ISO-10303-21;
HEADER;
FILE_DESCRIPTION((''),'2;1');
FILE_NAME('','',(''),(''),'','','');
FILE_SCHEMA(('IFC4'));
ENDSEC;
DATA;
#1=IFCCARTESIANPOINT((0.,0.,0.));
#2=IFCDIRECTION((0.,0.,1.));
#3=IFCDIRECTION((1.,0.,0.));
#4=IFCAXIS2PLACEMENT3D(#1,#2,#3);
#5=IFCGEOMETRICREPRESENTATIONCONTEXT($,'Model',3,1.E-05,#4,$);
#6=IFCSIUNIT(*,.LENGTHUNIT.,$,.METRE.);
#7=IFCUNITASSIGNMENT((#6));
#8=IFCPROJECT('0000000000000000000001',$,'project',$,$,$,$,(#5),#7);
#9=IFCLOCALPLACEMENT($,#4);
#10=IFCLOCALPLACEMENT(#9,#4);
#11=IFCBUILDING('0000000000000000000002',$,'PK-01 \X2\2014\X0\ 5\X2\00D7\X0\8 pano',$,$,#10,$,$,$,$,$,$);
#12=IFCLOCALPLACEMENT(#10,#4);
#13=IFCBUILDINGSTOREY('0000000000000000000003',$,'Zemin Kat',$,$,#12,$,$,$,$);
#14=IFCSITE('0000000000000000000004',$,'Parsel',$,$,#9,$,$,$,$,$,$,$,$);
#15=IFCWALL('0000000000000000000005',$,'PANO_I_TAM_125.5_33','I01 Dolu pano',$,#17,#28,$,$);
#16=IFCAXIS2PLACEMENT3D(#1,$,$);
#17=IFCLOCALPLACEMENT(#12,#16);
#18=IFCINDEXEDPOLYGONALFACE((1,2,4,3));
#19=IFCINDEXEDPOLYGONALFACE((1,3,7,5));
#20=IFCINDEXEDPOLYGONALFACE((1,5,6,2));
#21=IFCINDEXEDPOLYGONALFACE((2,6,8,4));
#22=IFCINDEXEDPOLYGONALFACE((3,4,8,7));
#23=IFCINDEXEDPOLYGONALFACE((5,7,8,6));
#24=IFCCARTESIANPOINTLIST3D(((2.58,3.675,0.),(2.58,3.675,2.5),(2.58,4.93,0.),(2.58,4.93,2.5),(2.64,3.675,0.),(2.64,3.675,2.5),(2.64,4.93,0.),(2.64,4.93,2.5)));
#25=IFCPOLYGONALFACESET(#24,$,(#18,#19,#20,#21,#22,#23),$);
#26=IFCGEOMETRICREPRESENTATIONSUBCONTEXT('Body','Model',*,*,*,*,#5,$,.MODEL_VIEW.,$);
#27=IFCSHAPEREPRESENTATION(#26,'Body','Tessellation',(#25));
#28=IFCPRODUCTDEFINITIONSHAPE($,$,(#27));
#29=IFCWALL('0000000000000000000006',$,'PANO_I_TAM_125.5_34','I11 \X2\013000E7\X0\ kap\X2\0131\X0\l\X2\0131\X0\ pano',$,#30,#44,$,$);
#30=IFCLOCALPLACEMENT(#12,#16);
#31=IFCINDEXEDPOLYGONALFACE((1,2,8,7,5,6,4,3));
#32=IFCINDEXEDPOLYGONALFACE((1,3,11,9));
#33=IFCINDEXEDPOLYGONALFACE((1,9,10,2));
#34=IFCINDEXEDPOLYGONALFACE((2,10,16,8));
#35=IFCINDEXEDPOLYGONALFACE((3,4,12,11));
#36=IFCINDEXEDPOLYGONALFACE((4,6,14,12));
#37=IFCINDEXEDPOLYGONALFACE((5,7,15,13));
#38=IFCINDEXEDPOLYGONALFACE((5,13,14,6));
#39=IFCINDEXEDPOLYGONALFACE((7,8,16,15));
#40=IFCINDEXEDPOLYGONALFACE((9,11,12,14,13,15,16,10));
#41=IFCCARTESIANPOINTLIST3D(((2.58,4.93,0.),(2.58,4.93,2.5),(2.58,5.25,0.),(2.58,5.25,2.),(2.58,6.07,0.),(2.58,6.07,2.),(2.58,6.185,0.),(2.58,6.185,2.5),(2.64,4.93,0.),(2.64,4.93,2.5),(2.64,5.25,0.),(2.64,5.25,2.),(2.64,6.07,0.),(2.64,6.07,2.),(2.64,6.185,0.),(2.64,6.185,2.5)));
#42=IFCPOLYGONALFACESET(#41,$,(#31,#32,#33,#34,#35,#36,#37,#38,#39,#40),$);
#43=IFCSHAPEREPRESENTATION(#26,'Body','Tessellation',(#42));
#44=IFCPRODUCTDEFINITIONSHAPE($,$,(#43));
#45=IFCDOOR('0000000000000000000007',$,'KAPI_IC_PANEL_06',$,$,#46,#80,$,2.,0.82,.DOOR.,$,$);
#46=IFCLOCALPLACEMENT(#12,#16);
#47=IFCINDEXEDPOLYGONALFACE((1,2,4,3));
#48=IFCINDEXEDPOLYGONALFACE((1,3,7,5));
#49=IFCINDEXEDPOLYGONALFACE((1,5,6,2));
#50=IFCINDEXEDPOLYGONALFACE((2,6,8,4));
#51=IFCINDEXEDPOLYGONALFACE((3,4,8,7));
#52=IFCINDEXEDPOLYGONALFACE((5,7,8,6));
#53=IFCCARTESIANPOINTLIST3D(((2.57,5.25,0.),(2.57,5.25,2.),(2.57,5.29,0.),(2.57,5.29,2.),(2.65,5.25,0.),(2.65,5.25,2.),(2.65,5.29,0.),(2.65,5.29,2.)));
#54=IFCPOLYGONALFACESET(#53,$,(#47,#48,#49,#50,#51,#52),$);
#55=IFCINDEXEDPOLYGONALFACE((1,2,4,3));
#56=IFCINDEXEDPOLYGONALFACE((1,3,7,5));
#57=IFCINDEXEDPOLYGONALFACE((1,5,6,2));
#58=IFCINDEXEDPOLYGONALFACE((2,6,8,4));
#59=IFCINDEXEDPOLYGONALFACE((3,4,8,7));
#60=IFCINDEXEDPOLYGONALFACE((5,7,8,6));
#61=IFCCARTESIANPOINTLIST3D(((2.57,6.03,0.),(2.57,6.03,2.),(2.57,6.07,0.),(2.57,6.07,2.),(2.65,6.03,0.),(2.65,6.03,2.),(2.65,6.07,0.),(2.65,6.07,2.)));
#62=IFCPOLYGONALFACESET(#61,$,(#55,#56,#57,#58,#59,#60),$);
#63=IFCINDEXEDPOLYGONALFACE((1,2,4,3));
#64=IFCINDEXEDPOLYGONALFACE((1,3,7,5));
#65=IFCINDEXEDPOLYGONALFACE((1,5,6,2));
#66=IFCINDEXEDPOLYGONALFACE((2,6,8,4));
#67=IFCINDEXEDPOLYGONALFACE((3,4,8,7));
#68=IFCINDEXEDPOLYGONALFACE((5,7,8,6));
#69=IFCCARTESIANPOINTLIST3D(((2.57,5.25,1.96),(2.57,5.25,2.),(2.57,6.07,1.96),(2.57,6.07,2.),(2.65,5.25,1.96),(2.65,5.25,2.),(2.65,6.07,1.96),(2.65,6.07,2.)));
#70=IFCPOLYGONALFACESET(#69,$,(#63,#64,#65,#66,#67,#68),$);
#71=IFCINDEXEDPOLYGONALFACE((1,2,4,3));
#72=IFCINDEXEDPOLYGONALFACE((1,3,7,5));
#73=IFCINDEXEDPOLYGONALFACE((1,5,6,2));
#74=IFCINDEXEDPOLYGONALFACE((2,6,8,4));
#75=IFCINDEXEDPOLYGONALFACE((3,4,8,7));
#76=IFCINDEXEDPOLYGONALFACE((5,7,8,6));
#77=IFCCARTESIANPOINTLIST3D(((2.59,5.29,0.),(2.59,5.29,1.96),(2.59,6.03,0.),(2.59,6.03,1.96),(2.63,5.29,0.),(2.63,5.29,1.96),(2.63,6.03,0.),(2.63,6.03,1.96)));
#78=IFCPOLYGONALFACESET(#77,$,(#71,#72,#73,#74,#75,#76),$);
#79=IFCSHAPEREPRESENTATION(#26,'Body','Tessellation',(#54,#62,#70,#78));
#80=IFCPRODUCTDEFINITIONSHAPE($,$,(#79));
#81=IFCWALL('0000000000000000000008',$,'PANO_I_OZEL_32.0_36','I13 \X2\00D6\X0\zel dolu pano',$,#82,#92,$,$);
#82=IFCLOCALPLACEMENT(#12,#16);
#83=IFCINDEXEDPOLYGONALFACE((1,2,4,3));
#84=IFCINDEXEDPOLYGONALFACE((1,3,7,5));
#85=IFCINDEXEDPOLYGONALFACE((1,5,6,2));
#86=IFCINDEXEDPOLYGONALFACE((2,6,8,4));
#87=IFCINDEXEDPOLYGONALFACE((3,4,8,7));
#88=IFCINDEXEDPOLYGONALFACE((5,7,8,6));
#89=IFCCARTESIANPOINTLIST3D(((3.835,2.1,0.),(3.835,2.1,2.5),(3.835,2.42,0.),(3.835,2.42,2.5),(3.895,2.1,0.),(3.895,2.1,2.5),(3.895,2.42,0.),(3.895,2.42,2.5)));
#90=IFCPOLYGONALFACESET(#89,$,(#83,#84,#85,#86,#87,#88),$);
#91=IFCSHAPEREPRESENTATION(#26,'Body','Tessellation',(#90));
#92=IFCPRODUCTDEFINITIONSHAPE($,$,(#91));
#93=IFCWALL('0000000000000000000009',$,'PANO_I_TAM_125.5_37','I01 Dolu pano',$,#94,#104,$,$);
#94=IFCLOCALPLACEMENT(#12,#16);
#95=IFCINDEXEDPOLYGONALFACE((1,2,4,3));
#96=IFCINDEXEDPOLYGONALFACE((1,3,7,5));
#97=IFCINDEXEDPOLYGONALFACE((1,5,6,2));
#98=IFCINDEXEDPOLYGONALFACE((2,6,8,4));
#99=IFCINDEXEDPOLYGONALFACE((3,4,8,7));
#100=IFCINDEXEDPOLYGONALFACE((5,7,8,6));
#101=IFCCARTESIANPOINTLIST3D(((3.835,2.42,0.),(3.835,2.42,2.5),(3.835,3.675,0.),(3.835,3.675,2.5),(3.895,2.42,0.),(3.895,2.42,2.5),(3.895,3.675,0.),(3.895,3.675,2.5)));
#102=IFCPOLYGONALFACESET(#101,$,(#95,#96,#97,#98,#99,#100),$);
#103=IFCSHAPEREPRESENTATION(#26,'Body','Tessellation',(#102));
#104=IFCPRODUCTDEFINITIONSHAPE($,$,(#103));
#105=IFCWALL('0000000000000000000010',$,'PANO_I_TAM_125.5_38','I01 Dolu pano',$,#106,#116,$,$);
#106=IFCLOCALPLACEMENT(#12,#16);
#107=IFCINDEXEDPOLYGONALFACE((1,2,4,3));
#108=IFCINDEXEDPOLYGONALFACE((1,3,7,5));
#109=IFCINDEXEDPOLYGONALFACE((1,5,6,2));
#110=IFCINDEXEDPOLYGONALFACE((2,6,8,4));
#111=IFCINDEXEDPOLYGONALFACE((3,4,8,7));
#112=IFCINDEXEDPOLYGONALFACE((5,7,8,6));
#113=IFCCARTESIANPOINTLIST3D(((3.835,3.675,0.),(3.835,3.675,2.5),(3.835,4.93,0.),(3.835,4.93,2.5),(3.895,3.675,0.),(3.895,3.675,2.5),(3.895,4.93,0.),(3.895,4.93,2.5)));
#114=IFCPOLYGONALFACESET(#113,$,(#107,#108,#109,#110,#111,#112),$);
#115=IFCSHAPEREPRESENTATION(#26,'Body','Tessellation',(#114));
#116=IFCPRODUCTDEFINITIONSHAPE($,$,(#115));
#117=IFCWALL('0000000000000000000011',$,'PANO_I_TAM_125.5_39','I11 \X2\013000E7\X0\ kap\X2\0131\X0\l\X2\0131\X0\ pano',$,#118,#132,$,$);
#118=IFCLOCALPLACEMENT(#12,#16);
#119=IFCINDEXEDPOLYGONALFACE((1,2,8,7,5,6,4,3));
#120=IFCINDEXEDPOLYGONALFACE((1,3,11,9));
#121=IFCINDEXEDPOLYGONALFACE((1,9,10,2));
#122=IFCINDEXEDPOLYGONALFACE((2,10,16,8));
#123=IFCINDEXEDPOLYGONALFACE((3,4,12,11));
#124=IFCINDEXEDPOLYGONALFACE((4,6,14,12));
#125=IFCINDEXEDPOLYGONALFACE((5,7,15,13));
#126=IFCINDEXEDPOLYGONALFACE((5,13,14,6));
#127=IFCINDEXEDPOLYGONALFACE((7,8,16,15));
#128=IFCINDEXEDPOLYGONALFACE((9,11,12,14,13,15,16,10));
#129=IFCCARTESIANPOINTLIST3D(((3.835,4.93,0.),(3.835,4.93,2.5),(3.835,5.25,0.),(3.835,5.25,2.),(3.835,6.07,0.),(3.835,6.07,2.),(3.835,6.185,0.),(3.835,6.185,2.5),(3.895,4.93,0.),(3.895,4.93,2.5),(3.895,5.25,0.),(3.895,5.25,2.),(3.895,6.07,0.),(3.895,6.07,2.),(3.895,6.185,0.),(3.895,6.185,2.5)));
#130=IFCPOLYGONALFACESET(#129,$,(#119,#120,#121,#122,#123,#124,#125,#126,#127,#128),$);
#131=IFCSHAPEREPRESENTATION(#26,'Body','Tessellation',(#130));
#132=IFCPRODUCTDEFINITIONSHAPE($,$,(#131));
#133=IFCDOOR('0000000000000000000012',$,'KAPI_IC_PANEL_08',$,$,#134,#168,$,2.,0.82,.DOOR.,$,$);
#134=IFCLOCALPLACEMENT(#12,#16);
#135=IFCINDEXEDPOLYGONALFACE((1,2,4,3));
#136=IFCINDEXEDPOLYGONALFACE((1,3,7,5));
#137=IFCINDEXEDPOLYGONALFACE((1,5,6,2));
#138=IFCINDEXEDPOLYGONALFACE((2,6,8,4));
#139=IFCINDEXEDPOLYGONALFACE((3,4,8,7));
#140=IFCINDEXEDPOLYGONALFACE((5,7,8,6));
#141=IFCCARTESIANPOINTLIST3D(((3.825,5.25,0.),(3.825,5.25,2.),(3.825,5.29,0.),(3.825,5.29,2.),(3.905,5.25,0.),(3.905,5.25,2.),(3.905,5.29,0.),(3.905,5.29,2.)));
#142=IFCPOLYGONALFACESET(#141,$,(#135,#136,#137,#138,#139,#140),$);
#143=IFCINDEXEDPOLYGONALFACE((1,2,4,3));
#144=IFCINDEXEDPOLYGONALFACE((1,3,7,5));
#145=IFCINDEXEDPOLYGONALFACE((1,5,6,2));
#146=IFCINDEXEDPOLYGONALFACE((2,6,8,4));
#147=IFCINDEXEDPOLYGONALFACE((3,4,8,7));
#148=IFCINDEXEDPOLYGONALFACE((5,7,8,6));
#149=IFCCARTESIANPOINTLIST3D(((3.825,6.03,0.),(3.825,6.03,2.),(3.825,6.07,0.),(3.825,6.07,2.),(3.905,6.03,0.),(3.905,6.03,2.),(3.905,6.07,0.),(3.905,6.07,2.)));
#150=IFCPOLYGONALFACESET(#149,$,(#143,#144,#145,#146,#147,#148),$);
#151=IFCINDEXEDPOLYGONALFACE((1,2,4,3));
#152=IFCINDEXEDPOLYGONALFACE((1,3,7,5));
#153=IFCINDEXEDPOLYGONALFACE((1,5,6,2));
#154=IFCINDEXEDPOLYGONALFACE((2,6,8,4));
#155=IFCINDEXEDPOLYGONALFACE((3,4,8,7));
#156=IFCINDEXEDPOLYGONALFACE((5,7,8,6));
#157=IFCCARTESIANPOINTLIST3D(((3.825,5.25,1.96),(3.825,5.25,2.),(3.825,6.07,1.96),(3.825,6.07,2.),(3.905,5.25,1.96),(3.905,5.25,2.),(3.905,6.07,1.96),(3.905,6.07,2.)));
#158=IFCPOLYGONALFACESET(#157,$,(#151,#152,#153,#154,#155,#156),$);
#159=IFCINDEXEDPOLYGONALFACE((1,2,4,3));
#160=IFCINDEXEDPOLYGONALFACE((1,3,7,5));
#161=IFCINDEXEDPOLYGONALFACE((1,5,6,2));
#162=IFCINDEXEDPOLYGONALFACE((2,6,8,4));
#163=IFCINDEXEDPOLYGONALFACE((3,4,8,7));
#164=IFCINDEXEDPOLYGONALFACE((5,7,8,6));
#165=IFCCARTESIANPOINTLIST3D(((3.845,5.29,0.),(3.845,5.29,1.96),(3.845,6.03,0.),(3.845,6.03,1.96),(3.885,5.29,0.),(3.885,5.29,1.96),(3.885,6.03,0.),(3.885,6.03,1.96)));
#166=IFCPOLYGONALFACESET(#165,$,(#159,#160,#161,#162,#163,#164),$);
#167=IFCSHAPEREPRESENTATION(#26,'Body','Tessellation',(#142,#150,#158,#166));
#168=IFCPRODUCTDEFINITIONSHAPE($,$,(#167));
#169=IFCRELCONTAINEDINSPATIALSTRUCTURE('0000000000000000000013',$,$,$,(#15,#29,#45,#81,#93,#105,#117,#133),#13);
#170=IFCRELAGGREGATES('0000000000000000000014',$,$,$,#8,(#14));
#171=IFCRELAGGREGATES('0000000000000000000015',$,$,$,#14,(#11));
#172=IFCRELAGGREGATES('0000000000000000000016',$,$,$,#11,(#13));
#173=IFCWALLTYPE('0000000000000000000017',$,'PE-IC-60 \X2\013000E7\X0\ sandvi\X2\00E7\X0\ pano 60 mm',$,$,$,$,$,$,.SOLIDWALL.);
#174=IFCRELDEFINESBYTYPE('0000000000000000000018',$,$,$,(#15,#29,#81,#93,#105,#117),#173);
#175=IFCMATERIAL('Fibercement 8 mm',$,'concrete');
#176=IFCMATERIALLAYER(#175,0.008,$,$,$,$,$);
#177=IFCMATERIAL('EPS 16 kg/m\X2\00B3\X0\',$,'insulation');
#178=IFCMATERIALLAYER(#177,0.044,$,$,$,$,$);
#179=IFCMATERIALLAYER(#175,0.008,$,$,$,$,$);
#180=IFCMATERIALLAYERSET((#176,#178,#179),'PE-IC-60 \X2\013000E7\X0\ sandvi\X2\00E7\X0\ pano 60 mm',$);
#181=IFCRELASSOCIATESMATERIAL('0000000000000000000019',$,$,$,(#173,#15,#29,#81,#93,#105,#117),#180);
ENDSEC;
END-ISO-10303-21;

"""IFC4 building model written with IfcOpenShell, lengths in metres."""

from ifc_helpers import new_model, si_unit, frame, origin_with_axes, place, context, subcontext, project, spatial, line, indexed_curve, outline, extrude, material, layer, layer_set, layer_usage, type_object, element, fill, save


model = new_model("IFC4")

# Units and contexts
model_context = context("Model", 3, precision=1e-05, world=origin_with_axes())
body_context = subcontext(model_context, "Body", "Model", "MODEL_VIEW")
ifc_project = project(units=[si_unit("LENGTHUNIT", "METRE")], contexts=[model_context])

# Site, building, storey
site_placement = place(None, origin_with_axes())
site = spatial("IfcSite", under=ifc_project, at=site_placement, Name="Parsel")
building_placement = place(site_placement, origin_with_axes())
building = spatial("IfcBuilding", under=site, at=building_placement, Name="PK-01 — 5×8 pano")
storey_placement = place(building_placement, origin_with_axes())
storey = spatial("IfcBuildingStorey", under=building, at=storey_placement, Name="Zemin Kat")

# Shared definitions
ifc_material_1 = material(Name="Fibercement 8 mm", Category="concrete")
ifc_material_2 = material(Name="EPS 16 kg/m³", Category="insulation")

# Wall
ifc_layer_1 = layer(ifc_material_1, 0.008)
ifc_layer_2 = layer(ifc_material_2, 0.044)
ifc_layer_3 = layer(ifc_material_1, 0.008)
ifc_layer_set_1 = layer_set([ifc_layer_1, ifc_layer_2, ifc_layer_3], Name="PE-IC-60 İç sandviç pano 60 mm")
wall_type_1 = type_object("IfcWallType", Name="PE-IC-60 İç sandviç pano 60 mm", PredefinedType="SOLIDWALL", material=ifc_layer_set_1)
ifc_layer_usage_1 = layer_usage(ifc_layer_set_1, "AXIS2", "POSITIVE", 0.0)
wall_1_placement = place(storey_placement, frame((2.64, 3.675, 0.0), z_axis=(0.0, 0.0, 1.0), x_axis=(0.0, 1.0, 0.0)))
element("IfcWall", 1, at=wall_1_placement, inside=storey, type_object=wall_type_1, material=ifc_layer_usage_1, Name="PANO_I_TAM_125.5_33", Description="I01 Dolu pano", context=body_context, shape_type="SweptSolid", body=[
    extrude(outline(indexed_curve([(0.0, 0.0), (1.255, 0.0), (1.255, 0.06), (0.0, 0.06)], segments=[line(1, 2, 3, 4, 1)])), origin_with_axes(), (0.0, 0.0, 1.0), 2.5),
])

# Wall, opening, door
ifc_layer_usage_2 = layer_usage(ifc_layer_set_1, "AXIS2", "POSITIVE", 0.0)
wall_2_placement = place(storey_placement, frame((2.64, 4.93, 0.0), z_axis=(0.0, 0.0, 1.0), x_axis=(0.0, 1.0, 0.0)))
wall_2 = element("IfcWall", 2, at=wall_2_placement, inside=storey, type_object=wall_type_1, material=ifc_layer_usage_2, Name="PANO_I_TAM_125.5_34", Description="I11 İç kapılı pano", context=body_context, shape_type="SweptSolid", body=[
    extrude(outline(indexed_curve([(0.0, 0.0), (1.255, 0.0), (1.255, 0.06), (0.0, 0.06)], segments=[line(1, 2, 3, 4, 1)])), origin_with_axes(), (0.0, 0.0, 1.0), 2.5),
])
opening_1_placement = place(wall_2_placement, origin_with_axes())
opening_1 = element("IfcOpeningElement", 3, at=opening_1_placement, cuts=wall_2, PredefinedType="OPENING", context=body_context, shape_type="SweptSolid", body=[
    extrude(outline(indexed_curve([(0.0, 0.0), (0.82, 0.0), (0.82, 0.1), (0.0, 0.1)], segments=[line(1, 2, 3, 4, 1)])), frame((0.32, -0.02, 0.0), z_axis=(0.0, 0.0, 1.0), x_axis=(1.0, 0.0, 0.0)), (0.0, 0.0, 1.0), 2.0),
])
door_1_placement = place(storey_placement, frame((2.64, 4.93, 0.0), z_axis=(0.0, 0.0, 1.0), x_axis=(0.0, 1.0, 0.0)))
door_1 = element("IfcDoor", 4, at=door_1_placement, inside=storey, Name="KAPI_IC_PANEL_06", OverallHeight=2.0, OverallWidth=0.82, PredefinedType="DOOR", context=body_context, shape_type="SweptSolid", body=[
    extrude(outline(indexed_curve([(0.0, 0.0), (0.04, 0.0), (0.04, 0.08), (0.0, 0.08)], segments=[line(1, 2, 3, 4, 1)])), frame((0.32, -0.01, 0.0), z_axis=(0.0, 0.0, 1.0), x_axis=(1.0, 0.0, 0.0)), (0.0, 0.0, 1.0), 2.0),
    extrude(outline(indexed_curve([(0.0, 0.0), (0.04, 0.0), (0.04, 0.08), (0.0, 0.08)], segments=[line(1, 2, 3, 4, 1)])), frame((1.1, -0.01, 0.0), z_axis=(0.0, 0.0, 1.0), x_axis=(1.0, 0.0, 0.0)), (0.0, 0.0, 1.0), 2.0),
    extrude(outline(indexed_curve([(0.0, 0.0), (0.82, 0.0), (0.82, 0.08), (0.0, 0.08)], segments=[line(1, 2, 3, 4, 1)])), frame((0.32, -0.01, 1.96), z_axis=(0.0, 0.0, 1.0), x_axis=(1.0, 0.0, 0.0)), (0.0, 0.0, 1.0), 0.04),
    extrude(outline(indexed_curve([(0.0, 0.0), (0.74, 0.0), (0.74, 0.04), (0.0, 0.04)], segments=[line(1, 2, 3, 4, 1)])), frame((0.36, 0.01, 0.0), z_axis=(0.0, 0.0, 1.0), x_axis=(1.0, 0.0, 0.0)), (0.0, 0.0, 1.0), 1.96),
])
fill(opening_1, door_1)

# Walls
ifc_layer_usage_3 = layer_usage(ifc_layer_set_1, "AXIS2", "POSITIVE", 0.0)
wall_3_placement = place(storey_placement, frame((3.895, 2.1, 0.0), z_axis=(0.0, 0.0, 1.0), x_axis=(0.0, 1.0, 0.0)))
element("IfcWall", 5, at=wall_3_placement, inside=storey, type_object=wall_type_1, material=ifc_layer_usage_3, Name="PANO_I_OZEL_32.0_36", Description="I13 Özel dolu pano", context=body_context, shape_type="SweptSolid", body=[
    extrude(outline(indexed_curve([(0.0, 0.0), (0.32, 0.0), (0.32, 0.06), (0.0, 0.06)], segments=[line(1, 2, 3, 4, 1)])), origin_with_axes(), (0.0, 0.0, 1.0), 2.5),
])
ifc_layer_usage_4 = layer_usage(ifc_layer_set_1, "AXIS2", "POSITIVE", 0.0)
wall_4_placement = place(storey_placement, frame((3.895, 2.42, 0.0), z_axis=(0.0, 0.0, 1.0), x_axis=(0.0, 1.0, 0.0)))
element("IfcWall", 6, at=wall_4_placement, inside=storey, type_object=wall_type_1, material=ifc_layer_usage_4, Name="PANO_I_TAM_125.5_37", Description="I01 Dolu pano", context=body_context, shape_type="SweptSolid", body=[
    extrude(outline(indexed_curve([(0.0, 0.0), (1.255, 0.0), (1.255, 0.06), (0.0, 0.06)], segments=[line(1, 2, 3, 4, 1)])), origin_with_axes(), (0.0, 0.0, 1.0), 2.5),
])
ifc_layer_usage_5 = layer_usage(ifc_layer_set_1, "AXIS2", "POSITIVE", 0.0)
wall_5_placement = place(storey_placement, frame((3.895, 3.675, 0.0), z_axis=(0.0, 0.0, 1.0), x_axis=(0.0, 1.0, 0.0)))
element("IfcWall", 7, at=wall_5_placement, inside=storey, type_object=wall_type_1, material=ifc_layer_usage_5, Name="PANO_I_TAM_125.5_38", Description="I01 Dolu pano", context=body_context, shape_type="SweptSolid", body=[
    extrude(outline(indexed_curve([(0.0, 0.0), (1.255, 0.0), (1.255, 0.06), (0.0, 0.06)], segments=[line(1, 2, 3, 4, 1)])), origin_with_axes(), (0.0, 0.0, 1.0), 2.5),
])

# Wall, opening, door
ifc_layer_usage_6 = layer_usage(ifc_layer_set_1, "AXIS2", "POSITIVE", 0.0)
wall_6_placement = place(storey_placement, frame((3.895, 4.93, 0.0), z_axis=(0.0, 0.0, 1.0), x_axis=(0.0, 1.0, 0.0)))
wall_6 = element("IfcWall", 8, at=wall_6_placement, inside=storey, type_object=wall_type_1, material=ifc_layer_usage_6, Name="PANO_I_TAM_125.5_39", Description="I11 İç kapılı pano", context=body_context, shape_type="SweptSolid", body=[
    extrude(outline(indexed_curve([(0.0, 0.0), (1.255, 0.0), (1.255, 0.06), (0.0, 0.06)], segments=[line(1, 2, 3, 4, 1)])), origin_with_axes(), (0.0, 0.0, 1.0), 2.5),
])
opening_2_placement = place(wall_6_placement, origin_with_axes())
opening_2 = element("IfcOpeningElement", 9, at=opening_2_placement, cuts=wall_6, PredefinedType="OPENING", context=body_context, shape_type="SweptSolid", body=[
    extrude(outline(indexed_curve([(0.0, 0.0), (0.82, 0.0), (0.82, 0.1), (0.0, 0.1)], segments=[line(1, 2, 3, 4, 1)])), frame((0.32, -0.02, 0.0), z_axis=(0.0, 0.0, 1.0), x_axis=(1.0, 0.0, 0.0)), (0.0, 0.0, 1.0), 2.0),
])
door_2_placement = place(storey_placement, frame((3.895, 4.93, 0.0), z_axis=(0.0, 0.0, 1.0), x_axis=(0.0, 1.0, 0.0)))
door_2 = element("IfcDoor", 10, at=door_2_placement, inside=storey, Name="KAPI_IC_PANEL_08", OverallHeight=2.0, OverallWidth=0.82, PredefinedType="DOOR", context=body_context, shape_type="SweptSolid", body=[
    extrude(outline(indexed_curve([(0.0, 0.0), (0.04, 0.0), (0.04, 0.08), (0.0, 0.08)], segments=[line(1, 2, 3, 4, 1)])), frame((0.32, -0.01, 0.0), z_axis=(0.0, 0.0, 1.0), x_axis=(1.0, 0.0, 0.0)), (0.0, 0.0, 1.0), 2.0),
    extrude(outline(indexed_curve([(0.0, 0.0), (0.04, 0.0), (0.04, 0.08), (0.0, 0.08)], segments=[line(1, 2, 3, 4, 1)])), frame((1.1, -0.01, 0.0), z_axis=(0.0, 0.0, 1.0), x_axis=(1.0, 0.0, 0.0)), (0.0, 0.0, 1.0), 2.0),
    extrude(outline(indexed_curve([(0.0, 0.0), (0.82, 0.0), (0.82, 0.08), (0.0, 0.08)], segments=[line(1, 2, 3, 4, 1)])), frame((0.32, -0.01, 1.96), z_axis=(0.0, 0.0, 1.0), x_axis=(1.0, 0.0, 0.0)), (0.0, 0.0, 1.0), 0.04),
    extrude(outline(indexed_curve([(0.0, 0.0), (0.74, 0.0), (0.74, 0.04), (0.0, 0.04)], segments=[line(1, 2, 3, 4, 1)])), frame((0.36, 0.01, 0.0), z_axis=(0.0, 0.0, 1.0), x_axis=(1.0, 0.0, 0.0)), (0.0, 0.0, 1.0), 1.96),
])
fill(opening_2, door_2)

save(model, "model.ifc")
